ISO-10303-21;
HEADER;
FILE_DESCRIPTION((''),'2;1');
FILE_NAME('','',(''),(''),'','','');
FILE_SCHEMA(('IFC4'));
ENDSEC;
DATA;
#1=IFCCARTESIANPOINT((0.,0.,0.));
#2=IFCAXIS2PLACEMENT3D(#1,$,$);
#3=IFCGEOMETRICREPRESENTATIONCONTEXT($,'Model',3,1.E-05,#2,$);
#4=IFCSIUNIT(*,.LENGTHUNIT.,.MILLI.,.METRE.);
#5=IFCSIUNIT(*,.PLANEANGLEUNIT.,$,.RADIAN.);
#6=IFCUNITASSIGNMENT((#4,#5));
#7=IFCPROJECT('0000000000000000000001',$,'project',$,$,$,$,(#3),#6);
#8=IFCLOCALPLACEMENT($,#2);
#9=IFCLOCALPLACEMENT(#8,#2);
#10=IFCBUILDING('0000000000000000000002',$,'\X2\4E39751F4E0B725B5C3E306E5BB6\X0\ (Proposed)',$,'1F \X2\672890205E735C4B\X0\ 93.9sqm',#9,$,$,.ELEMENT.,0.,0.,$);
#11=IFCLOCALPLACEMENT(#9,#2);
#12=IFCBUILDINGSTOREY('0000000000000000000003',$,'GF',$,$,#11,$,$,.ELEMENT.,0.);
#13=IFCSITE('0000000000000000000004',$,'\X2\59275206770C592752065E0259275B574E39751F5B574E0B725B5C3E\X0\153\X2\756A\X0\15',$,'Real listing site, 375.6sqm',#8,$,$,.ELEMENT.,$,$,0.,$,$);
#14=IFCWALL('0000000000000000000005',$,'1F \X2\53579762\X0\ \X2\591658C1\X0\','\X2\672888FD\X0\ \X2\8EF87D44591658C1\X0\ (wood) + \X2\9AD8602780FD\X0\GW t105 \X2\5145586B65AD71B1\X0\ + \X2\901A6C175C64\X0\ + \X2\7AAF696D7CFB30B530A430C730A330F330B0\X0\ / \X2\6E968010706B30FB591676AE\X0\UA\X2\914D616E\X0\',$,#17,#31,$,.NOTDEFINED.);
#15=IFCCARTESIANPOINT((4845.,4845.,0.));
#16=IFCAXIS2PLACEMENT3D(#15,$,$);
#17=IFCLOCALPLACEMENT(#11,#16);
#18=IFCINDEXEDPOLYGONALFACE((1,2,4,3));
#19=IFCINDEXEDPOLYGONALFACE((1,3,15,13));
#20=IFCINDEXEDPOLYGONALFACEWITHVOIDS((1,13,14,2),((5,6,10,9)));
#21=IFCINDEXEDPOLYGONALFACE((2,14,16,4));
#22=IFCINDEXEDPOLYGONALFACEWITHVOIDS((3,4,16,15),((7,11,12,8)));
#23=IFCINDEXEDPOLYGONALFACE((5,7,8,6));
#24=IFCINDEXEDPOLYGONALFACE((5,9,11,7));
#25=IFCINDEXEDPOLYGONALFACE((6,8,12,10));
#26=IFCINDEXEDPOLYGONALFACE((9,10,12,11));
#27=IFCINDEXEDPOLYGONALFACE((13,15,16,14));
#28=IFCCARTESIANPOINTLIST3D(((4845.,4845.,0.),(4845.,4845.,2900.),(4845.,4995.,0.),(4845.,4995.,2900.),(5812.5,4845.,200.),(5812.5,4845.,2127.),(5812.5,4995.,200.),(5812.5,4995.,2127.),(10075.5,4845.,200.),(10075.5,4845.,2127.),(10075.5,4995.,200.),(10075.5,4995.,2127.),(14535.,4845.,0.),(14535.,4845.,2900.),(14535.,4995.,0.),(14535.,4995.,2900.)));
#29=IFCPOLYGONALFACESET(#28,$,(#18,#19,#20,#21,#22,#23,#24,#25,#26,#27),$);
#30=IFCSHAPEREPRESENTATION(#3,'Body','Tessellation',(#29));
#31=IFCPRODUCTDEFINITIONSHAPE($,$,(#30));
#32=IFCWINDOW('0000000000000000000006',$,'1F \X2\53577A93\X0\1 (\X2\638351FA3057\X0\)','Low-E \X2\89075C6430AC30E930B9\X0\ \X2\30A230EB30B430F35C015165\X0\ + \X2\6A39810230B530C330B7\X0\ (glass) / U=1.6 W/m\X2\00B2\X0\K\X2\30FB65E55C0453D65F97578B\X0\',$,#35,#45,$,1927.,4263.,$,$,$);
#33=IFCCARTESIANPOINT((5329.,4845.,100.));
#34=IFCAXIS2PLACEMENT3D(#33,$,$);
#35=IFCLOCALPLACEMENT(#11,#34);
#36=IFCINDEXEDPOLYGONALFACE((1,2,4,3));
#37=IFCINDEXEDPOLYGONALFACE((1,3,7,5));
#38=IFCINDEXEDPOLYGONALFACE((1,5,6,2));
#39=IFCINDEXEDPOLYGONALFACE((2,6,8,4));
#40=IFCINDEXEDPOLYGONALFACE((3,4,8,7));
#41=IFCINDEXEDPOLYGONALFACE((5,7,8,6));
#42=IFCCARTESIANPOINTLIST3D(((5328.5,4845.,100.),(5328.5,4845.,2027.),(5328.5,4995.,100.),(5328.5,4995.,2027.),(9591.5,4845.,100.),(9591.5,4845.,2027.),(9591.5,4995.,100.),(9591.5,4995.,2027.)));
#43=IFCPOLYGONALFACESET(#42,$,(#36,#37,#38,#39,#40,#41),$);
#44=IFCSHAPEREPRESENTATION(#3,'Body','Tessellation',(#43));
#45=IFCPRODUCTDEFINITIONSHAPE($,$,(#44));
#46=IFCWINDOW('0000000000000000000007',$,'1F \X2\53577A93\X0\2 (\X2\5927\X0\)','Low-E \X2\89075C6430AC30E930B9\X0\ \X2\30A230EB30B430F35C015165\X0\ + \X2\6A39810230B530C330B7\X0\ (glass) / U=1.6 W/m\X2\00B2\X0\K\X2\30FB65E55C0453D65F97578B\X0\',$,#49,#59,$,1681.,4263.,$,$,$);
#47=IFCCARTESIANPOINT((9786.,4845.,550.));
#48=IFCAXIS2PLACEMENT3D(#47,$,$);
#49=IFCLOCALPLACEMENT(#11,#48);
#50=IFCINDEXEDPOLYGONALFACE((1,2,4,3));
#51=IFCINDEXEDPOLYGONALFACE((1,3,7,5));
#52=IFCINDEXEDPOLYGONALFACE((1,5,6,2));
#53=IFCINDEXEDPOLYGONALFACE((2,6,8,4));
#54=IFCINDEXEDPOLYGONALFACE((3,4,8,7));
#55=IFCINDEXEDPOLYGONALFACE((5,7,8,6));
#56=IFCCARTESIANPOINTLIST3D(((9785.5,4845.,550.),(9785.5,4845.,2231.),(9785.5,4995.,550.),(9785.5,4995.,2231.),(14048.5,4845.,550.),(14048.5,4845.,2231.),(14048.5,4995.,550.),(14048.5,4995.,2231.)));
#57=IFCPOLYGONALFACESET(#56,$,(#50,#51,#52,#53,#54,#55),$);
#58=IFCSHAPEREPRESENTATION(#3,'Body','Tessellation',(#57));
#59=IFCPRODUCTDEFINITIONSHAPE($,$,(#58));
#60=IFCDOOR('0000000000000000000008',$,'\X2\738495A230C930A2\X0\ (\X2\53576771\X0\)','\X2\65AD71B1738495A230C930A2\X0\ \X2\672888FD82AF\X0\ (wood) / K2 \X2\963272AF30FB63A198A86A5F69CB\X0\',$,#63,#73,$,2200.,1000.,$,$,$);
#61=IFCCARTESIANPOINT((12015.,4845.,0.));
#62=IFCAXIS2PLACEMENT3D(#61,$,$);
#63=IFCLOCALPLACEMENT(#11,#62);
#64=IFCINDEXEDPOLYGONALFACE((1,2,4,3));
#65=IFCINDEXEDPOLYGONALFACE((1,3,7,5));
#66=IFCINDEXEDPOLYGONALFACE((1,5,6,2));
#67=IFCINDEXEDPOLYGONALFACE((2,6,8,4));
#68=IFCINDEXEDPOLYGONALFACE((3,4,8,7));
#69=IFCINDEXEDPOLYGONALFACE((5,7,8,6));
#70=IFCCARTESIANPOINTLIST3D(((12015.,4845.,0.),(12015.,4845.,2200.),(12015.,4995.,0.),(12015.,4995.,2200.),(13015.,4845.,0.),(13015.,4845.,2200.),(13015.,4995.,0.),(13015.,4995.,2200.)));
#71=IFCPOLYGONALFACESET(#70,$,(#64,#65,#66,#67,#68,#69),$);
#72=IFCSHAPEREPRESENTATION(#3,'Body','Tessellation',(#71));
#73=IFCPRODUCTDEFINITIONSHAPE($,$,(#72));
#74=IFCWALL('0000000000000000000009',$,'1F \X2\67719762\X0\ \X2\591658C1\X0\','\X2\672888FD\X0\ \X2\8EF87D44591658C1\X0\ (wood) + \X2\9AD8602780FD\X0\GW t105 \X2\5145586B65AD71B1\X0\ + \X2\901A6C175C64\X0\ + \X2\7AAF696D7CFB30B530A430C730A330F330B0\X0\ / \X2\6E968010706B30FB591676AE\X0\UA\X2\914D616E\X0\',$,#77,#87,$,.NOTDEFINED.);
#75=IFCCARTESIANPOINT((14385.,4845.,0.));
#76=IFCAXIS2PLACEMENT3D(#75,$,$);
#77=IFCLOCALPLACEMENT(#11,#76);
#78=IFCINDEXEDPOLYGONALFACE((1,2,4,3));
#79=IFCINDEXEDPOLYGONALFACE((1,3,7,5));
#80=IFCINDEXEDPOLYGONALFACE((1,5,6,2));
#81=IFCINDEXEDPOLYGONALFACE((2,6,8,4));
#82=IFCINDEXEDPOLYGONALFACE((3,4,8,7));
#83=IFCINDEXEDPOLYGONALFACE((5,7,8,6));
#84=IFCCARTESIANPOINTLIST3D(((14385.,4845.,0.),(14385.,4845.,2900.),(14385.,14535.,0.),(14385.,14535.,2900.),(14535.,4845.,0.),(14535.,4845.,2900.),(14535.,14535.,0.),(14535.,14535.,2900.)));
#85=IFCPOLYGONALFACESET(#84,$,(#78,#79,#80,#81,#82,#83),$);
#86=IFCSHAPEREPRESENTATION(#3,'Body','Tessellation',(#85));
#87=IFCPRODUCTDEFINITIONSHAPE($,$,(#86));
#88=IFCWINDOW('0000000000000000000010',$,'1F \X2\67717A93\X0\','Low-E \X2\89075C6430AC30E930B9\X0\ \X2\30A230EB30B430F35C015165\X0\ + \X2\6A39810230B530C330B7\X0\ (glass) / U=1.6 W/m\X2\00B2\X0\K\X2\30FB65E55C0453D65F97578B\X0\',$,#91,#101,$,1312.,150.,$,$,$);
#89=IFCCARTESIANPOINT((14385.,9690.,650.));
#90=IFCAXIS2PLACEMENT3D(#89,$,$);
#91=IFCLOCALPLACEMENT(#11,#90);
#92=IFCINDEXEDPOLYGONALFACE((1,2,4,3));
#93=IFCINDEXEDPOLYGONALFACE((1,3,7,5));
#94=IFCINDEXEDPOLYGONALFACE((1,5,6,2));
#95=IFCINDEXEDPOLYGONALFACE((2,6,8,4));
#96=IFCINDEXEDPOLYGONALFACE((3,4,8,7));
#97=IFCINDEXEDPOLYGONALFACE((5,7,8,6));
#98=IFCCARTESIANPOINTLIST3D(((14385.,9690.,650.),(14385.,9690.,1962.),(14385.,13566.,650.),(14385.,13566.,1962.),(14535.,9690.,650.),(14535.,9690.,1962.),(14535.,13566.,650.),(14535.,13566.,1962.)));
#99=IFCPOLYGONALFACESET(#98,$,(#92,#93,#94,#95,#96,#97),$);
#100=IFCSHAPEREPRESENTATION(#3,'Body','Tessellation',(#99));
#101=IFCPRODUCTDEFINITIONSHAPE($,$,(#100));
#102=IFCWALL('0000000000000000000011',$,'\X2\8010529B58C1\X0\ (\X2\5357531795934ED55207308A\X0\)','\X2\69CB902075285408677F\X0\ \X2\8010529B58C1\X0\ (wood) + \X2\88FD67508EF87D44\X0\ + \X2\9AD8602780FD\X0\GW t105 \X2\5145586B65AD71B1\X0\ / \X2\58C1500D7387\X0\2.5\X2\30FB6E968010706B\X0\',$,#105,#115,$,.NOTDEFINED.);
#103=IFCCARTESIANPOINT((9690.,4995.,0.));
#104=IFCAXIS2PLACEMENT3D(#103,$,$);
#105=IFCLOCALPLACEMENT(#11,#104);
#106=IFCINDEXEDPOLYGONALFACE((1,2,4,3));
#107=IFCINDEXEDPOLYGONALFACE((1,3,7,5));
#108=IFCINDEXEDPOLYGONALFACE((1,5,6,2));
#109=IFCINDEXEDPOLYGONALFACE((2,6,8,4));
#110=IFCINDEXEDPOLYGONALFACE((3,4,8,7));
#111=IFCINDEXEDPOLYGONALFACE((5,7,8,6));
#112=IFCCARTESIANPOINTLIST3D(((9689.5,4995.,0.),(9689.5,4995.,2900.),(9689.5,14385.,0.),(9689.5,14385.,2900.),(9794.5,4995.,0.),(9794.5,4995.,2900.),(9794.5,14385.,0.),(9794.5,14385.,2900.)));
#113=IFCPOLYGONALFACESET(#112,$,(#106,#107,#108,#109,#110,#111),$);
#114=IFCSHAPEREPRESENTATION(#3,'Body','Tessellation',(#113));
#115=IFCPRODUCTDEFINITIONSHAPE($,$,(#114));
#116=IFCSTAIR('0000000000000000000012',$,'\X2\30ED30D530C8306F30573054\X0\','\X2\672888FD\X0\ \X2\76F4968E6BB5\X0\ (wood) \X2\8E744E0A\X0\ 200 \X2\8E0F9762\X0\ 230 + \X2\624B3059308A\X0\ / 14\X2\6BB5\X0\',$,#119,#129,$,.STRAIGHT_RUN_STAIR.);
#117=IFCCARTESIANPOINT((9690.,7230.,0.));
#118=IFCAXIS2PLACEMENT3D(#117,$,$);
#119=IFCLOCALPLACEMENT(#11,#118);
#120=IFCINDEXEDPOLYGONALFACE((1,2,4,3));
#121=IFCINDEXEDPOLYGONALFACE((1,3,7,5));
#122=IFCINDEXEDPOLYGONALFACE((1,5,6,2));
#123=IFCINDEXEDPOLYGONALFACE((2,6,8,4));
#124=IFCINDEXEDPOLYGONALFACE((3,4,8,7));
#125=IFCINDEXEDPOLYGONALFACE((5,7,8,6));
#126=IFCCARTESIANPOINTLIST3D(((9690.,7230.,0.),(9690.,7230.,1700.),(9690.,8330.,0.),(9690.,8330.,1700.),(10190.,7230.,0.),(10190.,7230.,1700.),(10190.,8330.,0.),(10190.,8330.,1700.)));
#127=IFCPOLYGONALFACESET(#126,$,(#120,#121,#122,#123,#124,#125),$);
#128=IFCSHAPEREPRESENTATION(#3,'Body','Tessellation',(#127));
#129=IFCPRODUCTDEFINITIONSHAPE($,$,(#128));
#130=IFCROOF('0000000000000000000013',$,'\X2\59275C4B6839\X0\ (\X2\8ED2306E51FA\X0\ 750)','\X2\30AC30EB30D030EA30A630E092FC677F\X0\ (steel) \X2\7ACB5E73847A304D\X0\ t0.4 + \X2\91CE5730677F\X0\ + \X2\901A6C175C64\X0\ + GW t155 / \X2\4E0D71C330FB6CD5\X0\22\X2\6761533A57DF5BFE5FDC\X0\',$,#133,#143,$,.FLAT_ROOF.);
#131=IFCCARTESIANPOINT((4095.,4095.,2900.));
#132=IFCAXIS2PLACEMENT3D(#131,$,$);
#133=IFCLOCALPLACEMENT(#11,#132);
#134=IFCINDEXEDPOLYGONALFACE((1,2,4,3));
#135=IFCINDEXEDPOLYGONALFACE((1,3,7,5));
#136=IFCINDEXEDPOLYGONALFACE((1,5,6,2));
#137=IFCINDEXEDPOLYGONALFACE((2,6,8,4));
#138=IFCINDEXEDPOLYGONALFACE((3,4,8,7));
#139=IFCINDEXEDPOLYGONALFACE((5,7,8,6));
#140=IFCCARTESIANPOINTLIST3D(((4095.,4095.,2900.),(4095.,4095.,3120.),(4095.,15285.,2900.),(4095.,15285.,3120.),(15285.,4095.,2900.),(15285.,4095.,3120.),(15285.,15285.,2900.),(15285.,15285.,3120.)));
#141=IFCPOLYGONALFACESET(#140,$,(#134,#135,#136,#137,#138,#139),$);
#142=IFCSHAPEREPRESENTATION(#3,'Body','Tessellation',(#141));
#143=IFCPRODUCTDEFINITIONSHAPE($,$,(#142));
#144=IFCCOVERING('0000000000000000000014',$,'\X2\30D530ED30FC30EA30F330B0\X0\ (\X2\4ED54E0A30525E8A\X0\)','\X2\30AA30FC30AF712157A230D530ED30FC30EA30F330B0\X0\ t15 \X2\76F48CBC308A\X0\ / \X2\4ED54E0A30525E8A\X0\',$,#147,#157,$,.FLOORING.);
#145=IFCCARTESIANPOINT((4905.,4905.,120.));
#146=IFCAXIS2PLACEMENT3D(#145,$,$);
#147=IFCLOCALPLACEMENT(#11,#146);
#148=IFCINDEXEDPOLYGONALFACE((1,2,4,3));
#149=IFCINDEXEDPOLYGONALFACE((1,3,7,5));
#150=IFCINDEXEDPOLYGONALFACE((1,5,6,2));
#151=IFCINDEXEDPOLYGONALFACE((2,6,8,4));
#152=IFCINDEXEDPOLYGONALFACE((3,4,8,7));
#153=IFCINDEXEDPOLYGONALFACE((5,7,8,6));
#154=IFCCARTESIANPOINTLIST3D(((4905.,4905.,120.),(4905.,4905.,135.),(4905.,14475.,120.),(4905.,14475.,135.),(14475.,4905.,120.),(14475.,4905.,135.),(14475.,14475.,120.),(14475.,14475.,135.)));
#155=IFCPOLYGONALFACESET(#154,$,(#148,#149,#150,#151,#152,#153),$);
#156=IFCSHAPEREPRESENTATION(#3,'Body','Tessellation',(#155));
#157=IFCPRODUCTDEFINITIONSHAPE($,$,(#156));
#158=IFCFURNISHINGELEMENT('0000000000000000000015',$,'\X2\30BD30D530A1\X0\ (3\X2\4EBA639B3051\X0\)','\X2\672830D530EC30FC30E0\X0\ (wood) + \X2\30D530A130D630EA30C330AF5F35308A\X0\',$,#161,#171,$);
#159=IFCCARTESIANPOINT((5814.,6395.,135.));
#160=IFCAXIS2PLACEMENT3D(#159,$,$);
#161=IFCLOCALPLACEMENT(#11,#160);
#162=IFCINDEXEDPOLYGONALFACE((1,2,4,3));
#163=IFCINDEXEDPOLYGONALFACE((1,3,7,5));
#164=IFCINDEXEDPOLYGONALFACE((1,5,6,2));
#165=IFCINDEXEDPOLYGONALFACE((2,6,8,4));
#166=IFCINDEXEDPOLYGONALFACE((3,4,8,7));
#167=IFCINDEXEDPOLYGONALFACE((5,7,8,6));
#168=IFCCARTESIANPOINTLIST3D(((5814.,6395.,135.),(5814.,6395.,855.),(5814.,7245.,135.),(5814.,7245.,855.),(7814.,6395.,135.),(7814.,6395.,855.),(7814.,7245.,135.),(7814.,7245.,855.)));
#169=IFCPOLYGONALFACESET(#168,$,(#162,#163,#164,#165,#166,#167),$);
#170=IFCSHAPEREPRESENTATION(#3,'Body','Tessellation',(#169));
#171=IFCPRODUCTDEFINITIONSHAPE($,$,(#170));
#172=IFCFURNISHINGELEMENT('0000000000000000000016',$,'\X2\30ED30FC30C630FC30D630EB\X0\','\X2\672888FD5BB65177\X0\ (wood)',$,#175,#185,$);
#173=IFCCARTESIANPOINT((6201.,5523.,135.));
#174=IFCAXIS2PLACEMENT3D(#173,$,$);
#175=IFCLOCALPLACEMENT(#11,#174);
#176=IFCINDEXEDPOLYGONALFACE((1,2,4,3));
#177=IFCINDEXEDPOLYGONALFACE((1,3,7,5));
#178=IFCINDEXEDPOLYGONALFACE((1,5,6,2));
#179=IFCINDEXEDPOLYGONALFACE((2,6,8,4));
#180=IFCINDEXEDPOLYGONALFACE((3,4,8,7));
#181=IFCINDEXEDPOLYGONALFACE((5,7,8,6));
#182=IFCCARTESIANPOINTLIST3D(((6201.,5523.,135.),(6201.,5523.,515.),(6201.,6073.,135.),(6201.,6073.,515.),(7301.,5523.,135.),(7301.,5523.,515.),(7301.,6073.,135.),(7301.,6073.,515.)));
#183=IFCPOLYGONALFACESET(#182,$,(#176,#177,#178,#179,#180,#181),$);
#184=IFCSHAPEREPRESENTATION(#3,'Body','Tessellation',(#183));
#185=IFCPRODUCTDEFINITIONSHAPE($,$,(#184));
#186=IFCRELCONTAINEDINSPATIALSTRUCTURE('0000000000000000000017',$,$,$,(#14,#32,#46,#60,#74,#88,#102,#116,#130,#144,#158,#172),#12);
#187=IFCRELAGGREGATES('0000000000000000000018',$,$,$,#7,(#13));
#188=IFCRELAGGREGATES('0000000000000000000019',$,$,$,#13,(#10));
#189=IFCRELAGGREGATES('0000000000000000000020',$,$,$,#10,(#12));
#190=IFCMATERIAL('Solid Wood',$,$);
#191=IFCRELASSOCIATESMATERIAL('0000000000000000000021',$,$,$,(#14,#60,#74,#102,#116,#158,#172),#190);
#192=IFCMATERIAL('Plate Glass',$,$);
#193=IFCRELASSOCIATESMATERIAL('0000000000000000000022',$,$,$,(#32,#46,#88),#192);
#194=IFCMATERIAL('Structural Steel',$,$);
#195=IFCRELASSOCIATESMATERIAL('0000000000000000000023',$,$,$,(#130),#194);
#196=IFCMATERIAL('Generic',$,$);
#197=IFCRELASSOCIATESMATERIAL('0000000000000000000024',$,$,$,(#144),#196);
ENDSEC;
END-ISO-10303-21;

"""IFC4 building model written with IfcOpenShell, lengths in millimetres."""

from ifc_helpers import new_model, si_unit, frame, frame_2d, origin, place, context, project, spatial, rectangle, extrude, material, element, fill, save


model = new_model("IFC4")

# Units and contexts
model_context = context("Model", 3, precision=1e-05, world=origin())
ifc_project = project(units=[si_unit("LENGTHUNIT", "METRE", prefix="MILLI"), si_unit("PLANEANGLEUNIT", "RADIAN")], contexts=[model_context])

# Site, building, storey
site_placement = place(None, origin())
site = spatial("IfcSite", under=ifc_project, at=site_placement, Name="大分県大分市大字丹生字下牛尾153番15", ObjectType="Real listing site, 375.6sqm", CompositionType="ELEMENT", RefElevation=0.0)
building_placement = place(site_placement, origin())
building = spatial("IfcBuilding", under=site, at=building_placement, Name="丹生下牛尾の家 (Proposed)", ObjectType="1F 木造平屋 93.9sqm", CompositionType="ELEMENT", ElevationOfRefHeight=0.0, ElevationOfTerrain=0.0)
storey_placement = place(building_placement, origin())
storey = spatial("IfcBuildingStorey", under=building, at=storey_placement, Name="GF", CompositionType="ELEMENT", Elevation=0.0)

# Shared definitions
ifc_material_1 = material(Name="Solid Wood")

# Wall, openings, windows, door
wall_1_placement = place(storey_placement, frame((4845.0, 4845.0, 0.0)))
wall_1 = element("IfcWall", 1, at=wall_1_placement, inside=storey, material=ifc_material_1, Name="1F 南面 外壁", Description="木製 軸組外壁 (wood) + 高性能GW t105 充填断熱 + 通気層 + 窯業系サイディング / 準耐火・外皮UA配慮", PredefinedType="NOTDEFINED", context=model_context, shape_type="SweptSolid", body=[
    extrude(rectangle(XDim=9690.0, YDim=150.0, at=frame_2d((4845.0, 75.0))), frame((4845.0, 4845.0, 0.0)), (0.0, 0.0, 1.0), 2900.0),
])
opening_1_placement = place(storey_placement, frame((5329.0, 4845.0, 100.0)))
opening_1 = element("IfcOpeningElement", 2, at=opening_1_placement, cuts=wall_1, PredefinedType="NOTDEFINED", context=model_context, shape_type="SweptSolid", body=[
    extrude(rectangle(XDim=4263.0, YDim=150.0, at=frame_2d((2131.0, 75.0))), frame((5329.0, 4845.0, 100.0)), (0.0, 0.0, 1.0), 1927.0),
])
opening_2_placement = place(storey_placement, frame((9786.0, 4845.0, 550.0)))
opening_2 = element("IfcOpeningElement", 3, at=opening_2_placement, cuts=wall_1, PredefinedType="NOTDEFINED", context=model_context, shape_type="SweptSolid", body=[
    extrude(rectangle(XDim=4263.0, YDim=150.0, at=frame_2d((2131.0, 75.0))), frame((9786.0, 4845.0, 550.0)), (0.0, 0.0, 1.0), 1681.0),
])
opening_3_placement = place(storey_placement, frame((12015.0, 4845.0, 0.0)))
opening_3 = element("IfcOpeningElement", 4, at=opening_3_placement, cuts=wall_1, PredefinedType="NOTDEFINED", context=model_context, shape_type="SweptSolid", body=[
    extrude(rectangle(XDim=1000.0, YDim=150.0, at=frame_2d((500.0, 75.0))), frame((12015.0, 4845.0, 0.0)), (0.0, 0.0, 1.0), 2200.0),
])
ifc_material_2 = material(Name="Plate Glass")
window_1_placement = place(storey_placement, frame((5329.0, 4845.0, 100.0)))
window_1 = element("IfcWindow", 5, at=window_1_placement, inside=storey, material=ifc_material_2, Name="1F 南窓1 (掃出し)", Description="Low-E 複層ガラス アルゴン封入 + 樹脂サッシ (glass) / U=1.6 W/m²K・日射取得型", OverallHeight=1927.0, OverallWidth=4263.0, context=model_context, shape_type="SweptSolid", body=[
    extrude(rectangle(XDim=4263.0, YDim=150.0, at=frame_2d((2131.0, 75.0))), frame((5329.0, 4845.0, 100.0)), (0.0, 0.0, 1.0), 1927.0),
])
fill(opening_1, window_1)
window_2_placement = place(storey_placement, frame((9786.0, 4845.0, 550.0)))
window_2 = element("IfcWindow", 6, at=window_2_placement, inside=storey, material=ifc_material_2, Name="1F 南窓2 (大)", Description="Low-E 複層ガラス アルゴン封入 + 樹脂サッシ (glass) / U=1.6 W/m²K・日射取得型", OverallHeight=1681.0, OverallWidth=4263.0, context=model_context, shape_type="SweptSolid", body=[
    extrude(rectangle(XDim=4263.0, YDim=150.0, at=frame_2d((2131.0, 75.0))), frame((9786.0, 4845.0, 550.0)), (0.0, 0.0, 1.0), 1681.0),
])
fill(opening_2, window_2)
door_placement = place(storey_placement, frame((12015.0, 4845.0, 0.0)))
door = element("IfcDoor", 7, at=door_placement, inside=storey, material=ifc_material_1, Name="玄関ドア (南東)", Description="断熱玄関ドア 木製芯 (wood) / K2 防犯・採風機構", OverallHeight=2200.0, OverallWidth=1000.0, context=model_context, shape_type="SweptSolid", body=[
    extrude(rectangle(XDim=1000.0, YDim=150.0, at=frame_2d((500.0, 75.0))), frame((12015.0, 4845.0, 0.0)), (0.0, 0.0, 1.0), 2200.0),
])
fill(opening_3, door)

# Wall, opening, window
wall_2_placement = place(storey_placement, frame((14385.0, 4845.0, 0.0)))
wall_2 = element("IfcWall", 8, at=wall_2_placement, inside=storey, material=ifc_material_1, Name="1F 東面 外壁", Description="木製 軸組外壁 (wood) + 高性能GW t105 充填断熱 + 通気層 + 窯業系サイディング / 準耐火・外皮UA配慮", PredefinedType="NOTDEFINED", context=model_context, shape_type="SweptSolid", body=[
    extrude(rectangle(XDim=150.0, YDim=9690.0, at=frame_2d((75.0, 4845.0))), frame((14385.0, 4845.0, 0.0)), (0.0, 0.0, 1.0), 2900.0),
])
opening_4_placement = place(storey_placement, frame((14385.0, 9690.0, 650.0)))
opening_4 = element("IfcOpeningElement", 9, at=opening_4_placement, cuts=wall_2, PredefinedType="NOTDEFINED", context=model_context, shape_type="SweptSolid", body=[
    extrude(rectangle(XDim=150.0, YDim=3876.0, at=frame_2d((75.0, 1938.0))), frame((14385.0, 9690.0, 650.0)), (0.0, 0.0, 1.0), 1312.0),
])
window_3_placement = place(storey_placement, frame((14385.0, 9690.0, 650.0)))
window_3 = element("IfcWindow", 10, at=window_3_placement, inside=storey, material=ifc_material_2, Name="1F 東窓", Description="Low-E 複層ガラス アルゴン封入 + 樹脂サッシ (glass) / U=1.6 W/m²K・日射取得型", OverallHeight=1312.0, OverallWidth=150.0, context=model_context, shape_type="SweptSolid", body=[
    extrude(rectangle(XDim=150.0, YDim=3876.0, at=frame_2d((75.0, 1938.0))), frame((14385.0, 9690.0, 650.0)), (0.0, 0.0, 1.0), 1312.0),
])
fill(opening_4, window_3)

# Wall
wall_3_placement = place(storey_placement, frame((9690.0, 4995.0, 0.0)))
element("IfcWall", 11, at=wall_3_placement, inside=storey, material=ifc_material_1, Name="耐力壁 (南北間仕切り)", Description="構造用合板 耐力壁 (wood) + 製材軸組 + 高性能GW t105 充填断熱 / 壁倍率2.5・準耐火", PredefinedType="NOTDEFINED", context=model_context, shape_type="SweptSolid", body=[
    extrude(rectangle(XDim=105.0, YDim=9390.0, at=frame_2d((52.0, 4695.0))), frame((9690.0, 4995.0, 0.0)), (0.0, 0.0, 1.0), 2900.0),
])

# Stair
stair_placement = place(storey_placement, frame((9690.0, 7230.0, 0.0)))
element("IfcStair", 12, at=stair_placement, inside=storey, material=ifc_material_1, Name="ロフトはしご", Description="木製 直階段 (wood) 蹴上 200 踏面 230 + 手すり / 14段", PredefinedType="STRAIGHT_RUN_STAIR", context=model_context, shape_type="SweptSolid", body=[
    extrude(rectangle(XDim=500.0, YDim=1100.0, at=frame_2d((250.0, 550.0))), frame((9690.0, 7230.0, 0.0)), (0.0, 0.0, 1.0), 1700.0),
])

# Roof
ifc_material_3 = material(Name="Structural Steel")
roof_placement = place(storey_placement, frame((4095.0, 4095.0, 2900.0)))
element("IfcRoof", 13, at=roof_placement, inside=storey, material=ifc_material_3, Name="大屋根 (軒の出 750)", Description="ガルバリウム鋼板 (steel) 立平葺き t0.4 + 野地板 + 通気層 + GW t155 / 不燃・法22条区域対応", PredefinedType="FLAT_ROOF", context=model_context, shape_type="SweptSolid", body=[
    extrude(rectangle(XDim=11190.0, YDim=11190.0, at=frame_2d((5595.0, 5595.0))), frame((4095.0, 4095.0, 2900.0)), (0.0, 0.0, 1.0), 220.0),
])

# Covering
ifc_material_4 = material(Name="Generic")
covering_placement = place(storey_placement, frame((4905.0, 4905.0, 120.0)))
element("IfcCovering", 14, at=covering_placement, inside=storey, material=ifc_material_4, Name="フローリング (仕上げ床)", Description="オーク無垢フローリング t15 直貼り / 仕上げ床", PredefinedType="FLOORING", context=model_context, shape_type="SweptSolid", body=[
    extrude(rectangle(XDim=9570.0, YDim=9570.0, at=frame_2d((4785.0, 4785.0))), frame((4905.0, 4905.0, 120.0)), (0.0, 0.0, 1.0), 15.0),
])

# Furnishing elements
furnishing_1_placement = place(storey_placement, frame((5814.0, 6395.0, 135.0)))
element("IfcFurnishingElement", 15, at=furnishing_1_placement, inside=storey, material=ifc_material_1, Name="ソファ (3人掛け)", Description="木フレーム (wood) + ファブリック張り", context=model_context, shape_type="SweptSolid", body=[
    extrude(rectangle(XDim=2000.0, YDim=850.0, at=frame_2d((1000.0, 425.0))), frame((5814.0, 6395.0, 135.0)), (0.0, 0.0, 1.0), 720.0),
])
furnishing_2_placement = place(storey_placement, frame((6201.0, 5523.0, 135.0)))
element("IfcFurnishingElement", 16, at=furnishing_2_placement, inside=storey, material=ifc_material_1, Name="ローテーブル", Description="木製家具 (wood)", context=model_context, shape_type="SweptSolid", body=[
    extrude(rectangle(XDim=1100.0, YDim=550.0, at=frame_2d((550.0, 275.0))), frame((6201.0, 5523.0, 135.0)), (0.0, 0.0, 1.0), 380.0),
])

save(model, "model.ifc")
